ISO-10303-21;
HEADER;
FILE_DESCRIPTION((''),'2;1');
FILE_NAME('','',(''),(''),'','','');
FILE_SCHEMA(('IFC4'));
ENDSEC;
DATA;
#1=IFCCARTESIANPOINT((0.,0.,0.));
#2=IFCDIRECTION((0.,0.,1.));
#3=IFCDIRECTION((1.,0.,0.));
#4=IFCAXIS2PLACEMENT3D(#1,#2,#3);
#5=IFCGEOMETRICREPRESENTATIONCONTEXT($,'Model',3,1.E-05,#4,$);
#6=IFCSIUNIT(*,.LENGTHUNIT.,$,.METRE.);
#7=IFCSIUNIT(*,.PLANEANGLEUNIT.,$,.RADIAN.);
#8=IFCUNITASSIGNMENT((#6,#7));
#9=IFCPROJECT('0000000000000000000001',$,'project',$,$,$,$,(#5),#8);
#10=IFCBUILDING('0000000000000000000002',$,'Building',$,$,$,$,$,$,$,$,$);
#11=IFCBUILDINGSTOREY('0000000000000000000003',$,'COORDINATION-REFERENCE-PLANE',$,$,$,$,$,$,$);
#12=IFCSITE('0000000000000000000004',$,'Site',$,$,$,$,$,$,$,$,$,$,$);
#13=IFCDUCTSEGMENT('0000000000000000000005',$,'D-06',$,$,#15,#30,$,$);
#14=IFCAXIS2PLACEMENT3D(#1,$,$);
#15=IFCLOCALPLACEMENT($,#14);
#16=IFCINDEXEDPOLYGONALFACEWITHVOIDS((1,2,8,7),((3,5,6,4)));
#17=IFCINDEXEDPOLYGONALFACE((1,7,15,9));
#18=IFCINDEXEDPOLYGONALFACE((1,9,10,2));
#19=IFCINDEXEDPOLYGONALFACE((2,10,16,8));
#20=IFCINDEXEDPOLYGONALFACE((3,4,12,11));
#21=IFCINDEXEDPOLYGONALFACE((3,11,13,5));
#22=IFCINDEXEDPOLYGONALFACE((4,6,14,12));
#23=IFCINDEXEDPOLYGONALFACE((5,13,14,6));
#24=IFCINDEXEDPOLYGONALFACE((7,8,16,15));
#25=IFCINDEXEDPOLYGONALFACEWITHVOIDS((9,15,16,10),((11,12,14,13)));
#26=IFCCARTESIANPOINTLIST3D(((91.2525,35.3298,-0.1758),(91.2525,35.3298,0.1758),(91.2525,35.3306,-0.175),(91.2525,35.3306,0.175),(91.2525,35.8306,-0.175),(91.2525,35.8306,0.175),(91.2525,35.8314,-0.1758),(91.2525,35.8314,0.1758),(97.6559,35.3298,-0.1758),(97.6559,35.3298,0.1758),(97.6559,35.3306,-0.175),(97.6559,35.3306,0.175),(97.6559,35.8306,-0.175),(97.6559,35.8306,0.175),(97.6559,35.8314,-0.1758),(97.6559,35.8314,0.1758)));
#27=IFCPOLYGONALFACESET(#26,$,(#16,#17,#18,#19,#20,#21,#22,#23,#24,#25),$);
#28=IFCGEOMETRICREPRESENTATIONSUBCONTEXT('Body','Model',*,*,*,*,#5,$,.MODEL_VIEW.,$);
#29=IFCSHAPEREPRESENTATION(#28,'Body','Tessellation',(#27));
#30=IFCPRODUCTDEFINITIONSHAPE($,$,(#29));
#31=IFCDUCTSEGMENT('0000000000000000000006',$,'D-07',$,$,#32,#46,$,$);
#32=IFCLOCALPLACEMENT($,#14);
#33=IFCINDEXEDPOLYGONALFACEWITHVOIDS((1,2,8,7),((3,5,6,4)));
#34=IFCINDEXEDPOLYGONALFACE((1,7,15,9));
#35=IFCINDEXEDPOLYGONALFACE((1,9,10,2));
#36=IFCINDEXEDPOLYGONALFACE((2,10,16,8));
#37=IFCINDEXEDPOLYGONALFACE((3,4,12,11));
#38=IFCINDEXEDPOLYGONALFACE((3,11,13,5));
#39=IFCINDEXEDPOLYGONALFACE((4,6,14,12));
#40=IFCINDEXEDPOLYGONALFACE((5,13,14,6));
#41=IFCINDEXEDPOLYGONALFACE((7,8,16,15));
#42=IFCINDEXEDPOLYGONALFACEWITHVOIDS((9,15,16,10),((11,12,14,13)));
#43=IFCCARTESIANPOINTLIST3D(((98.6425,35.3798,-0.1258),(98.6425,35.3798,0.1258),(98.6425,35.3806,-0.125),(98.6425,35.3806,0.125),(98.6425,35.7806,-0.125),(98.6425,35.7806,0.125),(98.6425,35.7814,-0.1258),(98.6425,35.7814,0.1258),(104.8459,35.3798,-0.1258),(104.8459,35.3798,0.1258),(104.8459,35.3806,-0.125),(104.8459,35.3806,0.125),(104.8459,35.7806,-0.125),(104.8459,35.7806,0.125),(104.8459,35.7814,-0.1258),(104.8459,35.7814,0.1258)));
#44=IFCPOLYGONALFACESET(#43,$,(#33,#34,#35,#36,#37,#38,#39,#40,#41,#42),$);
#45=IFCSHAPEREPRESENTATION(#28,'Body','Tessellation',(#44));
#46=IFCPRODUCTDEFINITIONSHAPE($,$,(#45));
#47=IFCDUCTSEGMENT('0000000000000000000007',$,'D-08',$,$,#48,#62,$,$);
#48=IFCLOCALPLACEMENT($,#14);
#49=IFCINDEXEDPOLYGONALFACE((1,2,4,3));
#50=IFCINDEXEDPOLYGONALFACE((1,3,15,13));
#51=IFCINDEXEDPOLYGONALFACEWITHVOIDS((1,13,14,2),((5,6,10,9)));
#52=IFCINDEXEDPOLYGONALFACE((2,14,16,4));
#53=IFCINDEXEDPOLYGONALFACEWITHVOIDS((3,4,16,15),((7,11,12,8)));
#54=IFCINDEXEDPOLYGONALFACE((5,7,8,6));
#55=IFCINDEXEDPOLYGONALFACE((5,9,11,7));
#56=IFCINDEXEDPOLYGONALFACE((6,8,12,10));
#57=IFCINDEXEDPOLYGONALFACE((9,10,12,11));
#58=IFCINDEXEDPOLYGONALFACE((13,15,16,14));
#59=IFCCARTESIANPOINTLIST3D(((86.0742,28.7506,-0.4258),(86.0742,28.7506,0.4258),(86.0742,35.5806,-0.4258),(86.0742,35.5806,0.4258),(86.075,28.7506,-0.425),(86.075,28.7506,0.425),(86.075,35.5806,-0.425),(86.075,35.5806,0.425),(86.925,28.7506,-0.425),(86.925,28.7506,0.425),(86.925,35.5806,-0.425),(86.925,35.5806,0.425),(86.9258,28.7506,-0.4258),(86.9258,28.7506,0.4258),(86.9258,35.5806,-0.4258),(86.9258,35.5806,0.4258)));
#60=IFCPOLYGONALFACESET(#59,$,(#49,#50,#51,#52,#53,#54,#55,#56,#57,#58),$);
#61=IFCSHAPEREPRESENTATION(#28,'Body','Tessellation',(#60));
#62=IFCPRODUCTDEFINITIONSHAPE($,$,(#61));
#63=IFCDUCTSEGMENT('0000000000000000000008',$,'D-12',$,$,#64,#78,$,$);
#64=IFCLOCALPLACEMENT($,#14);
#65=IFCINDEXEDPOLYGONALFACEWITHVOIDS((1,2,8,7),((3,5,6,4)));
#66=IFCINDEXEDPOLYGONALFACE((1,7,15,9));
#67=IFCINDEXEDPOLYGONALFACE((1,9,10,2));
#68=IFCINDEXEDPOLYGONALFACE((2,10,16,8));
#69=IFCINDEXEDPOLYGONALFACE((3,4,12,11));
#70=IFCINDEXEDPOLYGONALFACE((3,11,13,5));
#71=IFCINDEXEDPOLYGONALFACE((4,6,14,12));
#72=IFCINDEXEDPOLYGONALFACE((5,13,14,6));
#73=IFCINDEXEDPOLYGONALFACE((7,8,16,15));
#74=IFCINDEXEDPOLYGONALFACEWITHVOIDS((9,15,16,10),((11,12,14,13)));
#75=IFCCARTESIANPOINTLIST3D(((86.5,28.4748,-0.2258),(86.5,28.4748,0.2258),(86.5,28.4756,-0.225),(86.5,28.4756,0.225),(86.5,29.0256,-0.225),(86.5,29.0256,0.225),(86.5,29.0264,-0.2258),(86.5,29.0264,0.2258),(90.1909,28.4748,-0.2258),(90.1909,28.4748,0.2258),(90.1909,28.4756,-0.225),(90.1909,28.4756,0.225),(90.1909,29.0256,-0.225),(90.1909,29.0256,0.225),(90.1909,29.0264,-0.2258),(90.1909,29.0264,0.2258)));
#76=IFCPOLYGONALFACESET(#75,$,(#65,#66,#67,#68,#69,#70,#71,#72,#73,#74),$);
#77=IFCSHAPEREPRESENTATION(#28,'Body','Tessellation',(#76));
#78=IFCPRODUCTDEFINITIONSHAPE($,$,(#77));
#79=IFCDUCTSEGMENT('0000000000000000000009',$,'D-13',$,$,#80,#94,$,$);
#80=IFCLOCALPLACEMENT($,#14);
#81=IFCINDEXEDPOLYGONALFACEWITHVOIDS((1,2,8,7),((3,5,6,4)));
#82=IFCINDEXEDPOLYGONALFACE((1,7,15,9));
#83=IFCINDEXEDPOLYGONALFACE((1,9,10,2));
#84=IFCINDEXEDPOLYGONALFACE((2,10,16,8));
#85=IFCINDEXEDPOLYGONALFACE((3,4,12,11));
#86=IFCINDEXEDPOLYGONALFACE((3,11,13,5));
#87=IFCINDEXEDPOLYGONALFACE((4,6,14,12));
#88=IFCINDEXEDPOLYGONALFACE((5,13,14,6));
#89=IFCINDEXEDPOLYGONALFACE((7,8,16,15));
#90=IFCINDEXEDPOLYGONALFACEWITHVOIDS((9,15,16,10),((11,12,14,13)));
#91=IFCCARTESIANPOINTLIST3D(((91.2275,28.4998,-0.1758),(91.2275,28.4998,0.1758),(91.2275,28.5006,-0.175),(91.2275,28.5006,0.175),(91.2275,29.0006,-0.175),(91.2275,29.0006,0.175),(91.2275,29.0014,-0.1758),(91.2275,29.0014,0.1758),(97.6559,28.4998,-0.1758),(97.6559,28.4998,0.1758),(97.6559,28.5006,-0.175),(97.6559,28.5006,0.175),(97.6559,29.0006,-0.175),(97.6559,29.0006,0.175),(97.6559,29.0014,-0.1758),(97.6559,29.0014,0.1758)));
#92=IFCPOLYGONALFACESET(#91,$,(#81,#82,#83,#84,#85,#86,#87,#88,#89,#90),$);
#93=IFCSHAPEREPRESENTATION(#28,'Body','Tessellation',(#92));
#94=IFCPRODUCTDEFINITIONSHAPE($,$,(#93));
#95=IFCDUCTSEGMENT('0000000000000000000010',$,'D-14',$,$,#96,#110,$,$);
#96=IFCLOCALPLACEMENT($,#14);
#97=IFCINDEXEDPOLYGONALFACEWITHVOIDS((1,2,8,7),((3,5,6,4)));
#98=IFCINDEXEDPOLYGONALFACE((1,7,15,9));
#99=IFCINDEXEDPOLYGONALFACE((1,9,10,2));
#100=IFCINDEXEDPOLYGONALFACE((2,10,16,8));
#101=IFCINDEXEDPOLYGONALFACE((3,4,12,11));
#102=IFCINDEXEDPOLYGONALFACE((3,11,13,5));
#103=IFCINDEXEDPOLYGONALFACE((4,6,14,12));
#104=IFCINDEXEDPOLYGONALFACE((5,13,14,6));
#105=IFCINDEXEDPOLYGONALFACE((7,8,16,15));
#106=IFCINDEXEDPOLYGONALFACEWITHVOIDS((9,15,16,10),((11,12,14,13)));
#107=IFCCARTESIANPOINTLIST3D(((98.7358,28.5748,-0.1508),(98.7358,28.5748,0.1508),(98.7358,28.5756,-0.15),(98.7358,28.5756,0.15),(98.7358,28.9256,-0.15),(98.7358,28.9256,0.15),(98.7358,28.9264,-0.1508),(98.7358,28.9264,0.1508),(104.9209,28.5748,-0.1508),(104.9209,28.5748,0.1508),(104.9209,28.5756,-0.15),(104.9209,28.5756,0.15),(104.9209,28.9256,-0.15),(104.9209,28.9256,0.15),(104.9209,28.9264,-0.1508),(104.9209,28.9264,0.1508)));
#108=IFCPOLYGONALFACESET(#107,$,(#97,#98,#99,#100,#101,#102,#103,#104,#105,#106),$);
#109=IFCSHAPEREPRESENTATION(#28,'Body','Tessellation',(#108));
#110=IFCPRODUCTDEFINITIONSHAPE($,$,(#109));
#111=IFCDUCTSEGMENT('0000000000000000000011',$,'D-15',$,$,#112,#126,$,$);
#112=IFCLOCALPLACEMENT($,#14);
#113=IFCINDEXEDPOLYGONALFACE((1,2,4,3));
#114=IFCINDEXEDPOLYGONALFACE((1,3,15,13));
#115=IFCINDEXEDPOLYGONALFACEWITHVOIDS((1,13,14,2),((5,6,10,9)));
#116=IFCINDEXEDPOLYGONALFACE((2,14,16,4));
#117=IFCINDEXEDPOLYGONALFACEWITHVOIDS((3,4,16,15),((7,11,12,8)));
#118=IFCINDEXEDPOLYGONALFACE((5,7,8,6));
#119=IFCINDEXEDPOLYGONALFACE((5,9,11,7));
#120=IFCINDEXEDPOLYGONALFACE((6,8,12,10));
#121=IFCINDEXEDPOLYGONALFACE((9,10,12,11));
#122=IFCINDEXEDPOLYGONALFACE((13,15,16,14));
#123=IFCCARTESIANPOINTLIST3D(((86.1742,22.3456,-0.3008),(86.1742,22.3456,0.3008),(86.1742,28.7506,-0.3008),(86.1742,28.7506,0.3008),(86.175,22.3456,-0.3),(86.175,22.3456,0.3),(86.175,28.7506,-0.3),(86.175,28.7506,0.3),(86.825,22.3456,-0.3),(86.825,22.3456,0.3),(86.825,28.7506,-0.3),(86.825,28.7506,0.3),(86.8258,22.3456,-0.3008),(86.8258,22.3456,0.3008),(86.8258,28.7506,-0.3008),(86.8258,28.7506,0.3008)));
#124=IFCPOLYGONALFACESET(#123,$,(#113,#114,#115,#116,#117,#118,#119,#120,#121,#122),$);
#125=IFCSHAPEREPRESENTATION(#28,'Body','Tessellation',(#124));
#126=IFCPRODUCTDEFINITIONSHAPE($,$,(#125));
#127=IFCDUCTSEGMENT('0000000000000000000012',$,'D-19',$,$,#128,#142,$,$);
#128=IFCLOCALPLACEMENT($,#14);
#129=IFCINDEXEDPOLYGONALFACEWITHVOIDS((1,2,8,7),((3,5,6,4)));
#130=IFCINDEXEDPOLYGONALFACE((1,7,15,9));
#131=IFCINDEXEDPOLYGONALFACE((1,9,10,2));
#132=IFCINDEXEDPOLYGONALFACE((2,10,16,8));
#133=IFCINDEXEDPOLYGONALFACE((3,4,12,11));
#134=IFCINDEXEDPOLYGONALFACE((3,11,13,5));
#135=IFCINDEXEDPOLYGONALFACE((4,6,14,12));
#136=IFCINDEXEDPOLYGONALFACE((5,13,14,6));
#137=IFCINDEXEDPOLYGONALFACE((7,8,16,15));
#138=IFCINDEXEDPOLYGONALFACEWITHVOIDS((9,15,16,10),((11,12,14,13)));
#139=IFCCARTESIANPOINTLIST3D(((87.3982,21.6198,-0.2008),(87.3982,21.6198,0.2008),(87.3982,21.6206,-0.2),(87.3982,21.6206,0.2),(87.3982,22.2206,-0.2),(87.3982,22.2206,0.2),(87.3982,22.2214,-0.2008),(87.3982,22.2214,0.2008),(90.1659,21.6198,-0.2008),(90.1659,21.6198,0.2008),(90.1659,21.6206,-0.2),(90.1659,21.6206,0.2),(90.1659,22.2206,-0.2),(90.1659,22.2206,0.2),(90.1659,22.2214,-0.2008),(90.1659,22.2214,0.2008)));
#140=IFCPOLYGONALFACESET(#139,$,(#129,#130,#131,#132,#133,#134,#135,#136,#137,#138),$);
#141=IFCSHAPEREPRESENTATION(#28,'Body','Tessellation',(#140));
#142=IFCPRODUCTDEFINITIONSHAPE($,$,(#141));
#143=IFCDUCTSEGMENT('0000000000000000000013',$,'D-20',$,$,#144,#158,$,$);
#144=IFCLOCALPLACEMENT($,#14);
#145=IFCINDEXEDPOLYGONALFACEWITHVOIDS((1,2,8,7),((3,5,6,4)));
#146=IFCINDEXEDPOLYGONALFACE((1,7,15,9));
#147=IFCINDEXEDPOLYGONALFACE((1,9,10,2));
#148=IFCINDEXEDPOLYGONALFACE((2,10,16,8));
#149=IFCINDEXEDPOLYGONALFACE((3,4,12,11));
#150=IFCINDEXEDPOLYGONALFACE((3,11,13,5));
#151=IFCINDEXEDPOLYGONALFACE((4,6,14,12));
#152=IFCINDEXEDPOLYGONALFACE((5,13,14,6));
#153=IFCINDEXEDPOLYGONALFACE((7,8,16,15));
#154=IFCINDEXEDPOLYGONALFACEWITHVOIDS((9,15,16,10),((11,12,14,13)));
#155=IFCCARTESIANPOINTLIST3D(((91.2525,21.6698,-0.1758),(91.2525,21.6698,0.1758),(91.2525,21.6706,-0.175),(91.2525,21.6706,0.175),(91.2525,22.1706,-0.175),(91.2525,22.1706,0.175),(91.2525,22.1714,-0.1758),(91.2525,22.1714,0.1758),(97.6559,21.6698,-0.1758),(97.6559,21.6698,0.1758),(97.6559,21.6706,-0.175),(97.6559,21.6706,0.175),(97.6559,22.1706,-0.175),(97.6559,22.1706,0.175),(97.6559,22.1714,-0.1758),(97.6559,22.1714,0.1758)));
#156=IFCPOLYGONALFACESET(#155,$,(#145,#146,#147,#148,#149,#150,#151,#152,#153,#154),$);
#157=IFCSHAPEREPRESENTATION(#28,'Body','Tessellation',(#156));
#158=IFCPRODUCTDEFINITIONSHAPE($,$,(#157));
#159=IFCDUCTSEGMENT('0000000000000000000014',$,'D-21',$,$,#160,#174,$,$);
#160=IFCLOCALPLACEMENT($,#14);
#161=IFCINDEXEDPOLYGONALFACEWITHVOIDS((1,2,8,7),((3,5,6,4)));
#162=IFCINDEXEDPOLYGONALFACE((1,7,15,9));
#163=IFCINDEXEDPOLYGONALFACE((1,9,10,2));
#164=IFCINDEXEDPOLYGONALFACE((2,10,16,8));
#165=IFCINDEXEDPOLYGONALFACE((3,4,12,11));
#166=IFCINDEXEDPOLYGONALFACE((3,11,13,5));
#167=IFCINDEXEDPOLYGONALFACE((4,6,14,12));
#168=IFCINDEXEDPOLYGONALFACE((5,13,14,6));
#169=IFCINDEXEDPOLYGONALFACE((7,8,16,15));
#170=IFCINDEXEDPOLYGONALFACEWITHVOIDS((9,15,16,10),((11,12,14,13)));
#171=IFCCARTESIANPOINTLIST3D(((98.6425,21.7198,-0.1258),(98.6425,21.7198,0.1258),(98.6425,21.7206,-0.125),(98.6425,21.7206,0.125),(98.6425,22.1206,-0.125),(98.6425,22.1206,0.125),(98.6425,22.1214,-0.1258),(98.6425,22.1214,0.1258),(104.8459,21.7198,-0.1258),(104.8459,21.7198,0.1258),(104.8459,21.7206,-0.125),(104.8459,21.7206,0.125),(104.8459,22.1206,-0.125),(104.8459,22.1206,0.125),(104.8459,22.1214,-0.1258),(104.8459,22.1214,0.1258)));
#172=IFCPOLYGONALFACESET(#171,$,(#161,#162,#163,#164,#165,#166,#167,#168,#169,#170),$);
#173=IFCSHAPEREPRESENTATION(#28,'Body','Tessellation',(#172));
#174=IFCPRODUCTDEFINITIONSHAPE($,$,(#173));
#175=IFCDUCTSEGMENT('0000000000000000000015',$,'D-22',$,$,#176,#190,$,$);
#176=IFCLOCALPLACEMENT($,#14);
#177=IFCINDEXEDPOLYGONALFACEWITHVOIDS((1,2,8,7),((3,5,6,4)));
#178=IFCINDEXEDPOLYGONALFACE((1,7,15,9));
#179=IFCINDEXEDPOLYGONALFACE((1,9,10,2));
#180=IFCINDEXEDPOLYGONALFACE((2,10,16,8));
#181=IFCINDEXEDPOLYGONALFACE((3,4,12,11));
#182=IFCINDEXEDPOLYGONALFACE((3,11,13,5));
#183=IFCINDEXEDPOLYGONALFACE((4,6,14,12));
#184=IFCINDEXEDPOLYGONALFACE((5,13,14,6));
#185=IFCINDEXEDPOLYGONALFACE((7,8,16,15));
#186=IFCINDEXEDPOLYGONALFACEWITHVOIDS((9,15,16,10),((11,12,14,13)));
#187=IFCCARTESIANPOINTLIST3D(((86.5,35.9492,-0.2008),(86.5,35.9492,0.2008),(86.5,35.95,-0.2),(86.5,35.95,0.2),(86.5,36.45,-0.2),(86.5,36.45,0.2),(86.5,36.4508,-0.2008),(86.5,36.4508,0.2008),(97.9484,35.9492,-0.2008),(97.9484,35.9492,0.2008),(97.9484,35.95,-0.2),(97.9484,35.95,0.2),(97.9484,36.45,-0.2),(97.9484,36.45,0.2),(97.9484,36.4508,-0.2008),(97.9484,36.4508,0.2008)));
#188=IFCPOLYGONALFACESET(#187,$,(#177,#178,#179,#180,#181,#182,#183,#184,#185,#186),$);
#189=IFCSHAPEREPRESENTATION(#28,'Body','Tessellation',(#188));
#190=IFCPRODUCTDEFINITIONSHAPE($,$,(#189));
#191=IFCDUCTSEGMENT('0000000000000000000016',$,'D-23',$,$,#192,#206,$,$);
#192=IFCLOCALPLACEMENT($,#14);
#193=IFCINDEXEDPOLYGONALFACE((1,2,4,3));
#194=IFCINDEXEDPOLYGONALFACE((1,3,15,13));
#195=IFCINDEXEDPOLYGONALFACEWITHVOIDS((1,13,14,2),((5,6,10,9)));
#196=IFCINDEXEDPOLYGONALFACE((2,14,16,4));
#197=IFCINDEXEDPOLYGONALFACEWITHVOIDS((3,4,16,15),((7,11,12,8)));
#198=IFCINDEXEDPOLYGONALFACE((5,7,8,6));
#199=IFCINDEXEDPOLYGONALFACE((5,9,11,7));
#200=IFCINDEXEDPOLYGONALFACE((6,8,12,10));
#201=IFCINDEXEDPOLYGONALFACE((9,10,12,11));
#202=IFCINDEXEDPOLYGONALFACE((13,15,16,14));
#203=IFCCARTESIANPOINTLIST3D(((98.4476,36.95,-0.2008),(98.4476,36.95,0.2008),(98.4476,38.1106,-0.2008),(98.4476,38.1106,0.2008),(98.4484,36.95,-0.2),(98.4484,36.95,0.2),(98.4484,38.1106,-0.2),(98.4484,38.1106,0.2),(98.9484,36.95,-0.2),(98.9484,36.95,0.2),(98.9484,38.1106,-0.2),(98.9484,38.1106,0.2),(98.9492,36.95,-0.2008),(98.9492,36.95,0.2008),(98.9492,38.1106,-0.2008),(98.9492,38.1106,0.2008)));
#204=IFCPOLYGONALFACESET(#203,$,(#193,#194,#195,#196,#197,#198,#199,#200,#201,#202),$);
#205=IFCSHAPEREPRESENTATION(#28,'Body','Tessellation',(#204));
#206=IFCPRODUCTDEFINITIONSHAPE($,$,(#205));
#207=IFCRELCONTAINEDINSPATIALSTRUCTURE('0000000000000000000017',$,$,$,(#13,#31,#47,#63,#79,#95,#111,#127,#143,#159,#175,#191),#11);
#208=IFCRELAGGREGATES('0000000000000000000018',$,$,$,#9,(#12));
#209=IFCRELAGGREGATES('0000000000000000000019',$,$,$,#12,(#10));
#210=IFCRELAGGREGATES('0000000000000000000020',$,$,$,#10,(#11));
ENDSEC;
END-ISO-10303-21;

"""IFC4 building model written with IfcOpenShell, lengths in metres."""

from ifc_helpers import new_model, si_unit, frame, origin, origin_with_axes, place, context, subcontext, project, spatial, hollow_rectangle, extrude, element, save


model = new_model("IFC4")

# Units and contexts
model_context = context("Model", 3, precision=1e-05, world=origin_with_axes())
body_context = subcontext(model_context, "Body", "Model", "MODEL_VIEW")
ifc_project = project(units=[si_unit("LENGTHUNIT", "METRE"), si_unit("PLANEANGLEUNIT", "RADIAN")], contexts=[model_context])

# Site, building, storey
site = spatial("IfcSite", under=ifc_project, Name="Site")
building = spatial("IfcBuilding", under=site, Name="Building")
storey = spatial("IfcBuildingStorey", under=building, Name="COORDINATION-REFERENCE-PLANE")

# Duct segments
duct_segment_1_placement = place(None, frame((91.2525, 35.5806, 0.0), z_axis=(1.0, 0.0, 0.0), x_axis=(0.0, 1.0, 0.0)))
element("IfcDuctSegment", 1, at=duct_segment_1_placement, inside=storey, Name="D-06", context=body_context, shape_type="SweptSolid", body=[
    extrude(hollow_rectangle(XDim=0.5016, YDim=0.3516, WallThickness=0.0008), origin(), (0.0, 0.0, 1.0), 6.4034),
])
duct_segment_2_placement = place(None, frame((98.6425, 35.5806, 0.0), z_axis=(1.0, 0.0, 0.0), x_axis=(0.0, 1.0, 0.0)))
element("IfcDuctSegment", 2, at=duct_segment_2_placement, inside=storey, Name="D-07", context=body_context, shape_type="SweptSolid", body=[
    extrude(hollow_rectangle(XDim=0.4016, YDim=0.2516, WallThickness=0.0008), origin(), (0.0, 0.0, 1.0), 6.2034),
])
duct_segment_3_placement = place(None, frame((86.5, 28.7506, 0.0), z_axis=(0.0, 1.0, 0.0), x_axis=(1.0, 0.0, 0.0)))
element("IfcDuctSegment", 3, at=duct_segment_3_placement, inside=storey, Name="D-08", context=body_context, shape_type="SweptSolid", body=[
    extrude(hollow_rectangle(XDim=0.8516, YDim=0.8516, WallThickness=0.0008), origin(), (0.0, 0.0, 1.0), 6.83),
])
duct_segment_4_placement = place(None, frame((86.5, 28.7506, 0.0), z_axis=(1.0, 0.0, 0.0), x_axis=(0.0, 1.0, 0.0)))
element("IfcDuctSegment", 4, at=duct_segment_4_placement, inside=storey, Name="D-12", context=body_context, shape_type="SweptSolid", body=[
    extrude(hollow_rectangle(XDim=0.5516, YDim=0.4516, WallThickness=0.0008), origin(), (0.0, 0.0, 1.0), 3.6909),
])
duct_segment_5_placement = place(None, frame((91.2275, 28.7506, 0.0), z_axis=(1.0, 0.0, 0.0), x_axis=(0.0, 1.0, 0.0)))
element("IfcDuctSegment", 5, at=duct_segment_5_placement, inside=storey, Name="D-13", context=body_context, shape_type="SweptSolid", body=[
    extrude(hollow_rectangle(XDim=0.5016, YDim=0.3516, WallThickness=0.0008), origin(), (0.0, 0.0, 1.0), 6.4284),
])
duct_segment_6_placement = place(None, frame((98.7358, 28.7506, 0.0), z_axis=(1.0, 0.0, 0.0), x_axis=(0.0, 1.0, 0.0)))
element("IfcDuctSegment", 6, at=duct_segment_6_placement, inside=storey, Name="D-14", context=body_context, shape_type="SweptSolid", body=[
    extrude(hollow_rectangle(XDim=0.3516, YDim=0.3016, WallThickness=0.0008), origin(), (0.0, 0.0, 1.0), 6.1851),
])
duct_segment_7_placement = place(None, frame((86.5, 22.3456, 0.0), z_axis=(0.0, 1.0, 0.0), x_axis=(1.0, 0.0, 0.0)))
element("IfcDuctSegment", 7, at=duct_segment_7_placement, inside=storey, Name="D-15", context=body_context, shape_type="SweptSolid", body=[
    extrude(hollow_rectangle(XDim=0.6516, YDim=0.6016, WallThickness=0.0008), origin(), (0.0, 0.0, 1.0), 6.405),
])
duct_segment_8_placement = place(None, frame((87.3982, 21.9206, 0.0), z_axis=(1.0, 0.0, 0.0), x_axis=(0.0, 1.0, 0.0)))
element("IfcDuctSegment", 8, at=duct_segment_8_placement, inside=storey, Name="D-19", context=body_context, shape_type="SweptSolid", body=[
    extrude(hollow_rectangle(XDim=0.6016, YDim=0.4016, WallThickness=0.0008), origin(), (0.0, 0.0, 1.0), 2.7677),
])
duct_segment_9_placement = place(None, frame((91.2525, 21.9206, 0.0), z_axis=(1.0, 0.0, 0.0), x_axis=(0.0, 1.0, 0.0)))
element("IfcDuctSegment", 9, at=duct_segment_9_placement, inside=storey, Name="D-20", context=body_context, shape_type="SweptSolid", body=[
    extrude(hollow_rectangle(XDim=0.5016, YDim=0.3516, WallThickness=0.0008), origin(), (0.0, 0.0, 1.0), 6.4034),
])
duct_segment_10_placement = place(None, frame((98.6425, 21.9206, 0.0), z_axis=(1.0, 0.0, 0.0), x_axis=(0.0, 1.0, 0.0)))
element("IfcDuctSegment", 10, at=duct_segment_10_placement, inside=storey, Name="D-21", context=body_context, shape_type="SweptSolid", body=[
    extrude(hollow_rectangle(XDim=0.4016, YDim=0.2516, WallThickness=0.0008), origin(), (0.0, 0.0, 1.0), 6.2034),
])
duct_segment_11_placement = place(None, frame((86.5, 36.2, 0.0), z_axis=(1.0, 0.0, 0.0), x_axis=(0.0, 1.0, 0.0)))
element("IfcDuctSegment", 11, at=duct_segment_11_placement, inside=storey, Name="D-22", context=body_context, shape_type="SweptSolid", body=[
    extrude(hollow_rectangle(XDim=0.5016, YDim=0.4016, WallThickness=0.0008), origin(), (0.0, 0.0, 1.0), 11.4484),
])
duct_segment_12_placement = place(None, frame((98.6984, 36.95, 0.0), z_axis=(0.0, 1.0, 0.0), x_axis=(1.0, 0.0, 0.0)))
element("IfcDuctSegment", 12, at=duct_segment_12_placement, inside=storey, Name="D-23", context=body_context, shape_type="SweptSolid", body=[
    extrude(hollow_rectangle(XDim=0.5016, YDim=0.4016, WallThickness=0.0008), origin(), (0.0, 0.0, 1.0), 1.1606),
])

save(model, "model.ifc")
